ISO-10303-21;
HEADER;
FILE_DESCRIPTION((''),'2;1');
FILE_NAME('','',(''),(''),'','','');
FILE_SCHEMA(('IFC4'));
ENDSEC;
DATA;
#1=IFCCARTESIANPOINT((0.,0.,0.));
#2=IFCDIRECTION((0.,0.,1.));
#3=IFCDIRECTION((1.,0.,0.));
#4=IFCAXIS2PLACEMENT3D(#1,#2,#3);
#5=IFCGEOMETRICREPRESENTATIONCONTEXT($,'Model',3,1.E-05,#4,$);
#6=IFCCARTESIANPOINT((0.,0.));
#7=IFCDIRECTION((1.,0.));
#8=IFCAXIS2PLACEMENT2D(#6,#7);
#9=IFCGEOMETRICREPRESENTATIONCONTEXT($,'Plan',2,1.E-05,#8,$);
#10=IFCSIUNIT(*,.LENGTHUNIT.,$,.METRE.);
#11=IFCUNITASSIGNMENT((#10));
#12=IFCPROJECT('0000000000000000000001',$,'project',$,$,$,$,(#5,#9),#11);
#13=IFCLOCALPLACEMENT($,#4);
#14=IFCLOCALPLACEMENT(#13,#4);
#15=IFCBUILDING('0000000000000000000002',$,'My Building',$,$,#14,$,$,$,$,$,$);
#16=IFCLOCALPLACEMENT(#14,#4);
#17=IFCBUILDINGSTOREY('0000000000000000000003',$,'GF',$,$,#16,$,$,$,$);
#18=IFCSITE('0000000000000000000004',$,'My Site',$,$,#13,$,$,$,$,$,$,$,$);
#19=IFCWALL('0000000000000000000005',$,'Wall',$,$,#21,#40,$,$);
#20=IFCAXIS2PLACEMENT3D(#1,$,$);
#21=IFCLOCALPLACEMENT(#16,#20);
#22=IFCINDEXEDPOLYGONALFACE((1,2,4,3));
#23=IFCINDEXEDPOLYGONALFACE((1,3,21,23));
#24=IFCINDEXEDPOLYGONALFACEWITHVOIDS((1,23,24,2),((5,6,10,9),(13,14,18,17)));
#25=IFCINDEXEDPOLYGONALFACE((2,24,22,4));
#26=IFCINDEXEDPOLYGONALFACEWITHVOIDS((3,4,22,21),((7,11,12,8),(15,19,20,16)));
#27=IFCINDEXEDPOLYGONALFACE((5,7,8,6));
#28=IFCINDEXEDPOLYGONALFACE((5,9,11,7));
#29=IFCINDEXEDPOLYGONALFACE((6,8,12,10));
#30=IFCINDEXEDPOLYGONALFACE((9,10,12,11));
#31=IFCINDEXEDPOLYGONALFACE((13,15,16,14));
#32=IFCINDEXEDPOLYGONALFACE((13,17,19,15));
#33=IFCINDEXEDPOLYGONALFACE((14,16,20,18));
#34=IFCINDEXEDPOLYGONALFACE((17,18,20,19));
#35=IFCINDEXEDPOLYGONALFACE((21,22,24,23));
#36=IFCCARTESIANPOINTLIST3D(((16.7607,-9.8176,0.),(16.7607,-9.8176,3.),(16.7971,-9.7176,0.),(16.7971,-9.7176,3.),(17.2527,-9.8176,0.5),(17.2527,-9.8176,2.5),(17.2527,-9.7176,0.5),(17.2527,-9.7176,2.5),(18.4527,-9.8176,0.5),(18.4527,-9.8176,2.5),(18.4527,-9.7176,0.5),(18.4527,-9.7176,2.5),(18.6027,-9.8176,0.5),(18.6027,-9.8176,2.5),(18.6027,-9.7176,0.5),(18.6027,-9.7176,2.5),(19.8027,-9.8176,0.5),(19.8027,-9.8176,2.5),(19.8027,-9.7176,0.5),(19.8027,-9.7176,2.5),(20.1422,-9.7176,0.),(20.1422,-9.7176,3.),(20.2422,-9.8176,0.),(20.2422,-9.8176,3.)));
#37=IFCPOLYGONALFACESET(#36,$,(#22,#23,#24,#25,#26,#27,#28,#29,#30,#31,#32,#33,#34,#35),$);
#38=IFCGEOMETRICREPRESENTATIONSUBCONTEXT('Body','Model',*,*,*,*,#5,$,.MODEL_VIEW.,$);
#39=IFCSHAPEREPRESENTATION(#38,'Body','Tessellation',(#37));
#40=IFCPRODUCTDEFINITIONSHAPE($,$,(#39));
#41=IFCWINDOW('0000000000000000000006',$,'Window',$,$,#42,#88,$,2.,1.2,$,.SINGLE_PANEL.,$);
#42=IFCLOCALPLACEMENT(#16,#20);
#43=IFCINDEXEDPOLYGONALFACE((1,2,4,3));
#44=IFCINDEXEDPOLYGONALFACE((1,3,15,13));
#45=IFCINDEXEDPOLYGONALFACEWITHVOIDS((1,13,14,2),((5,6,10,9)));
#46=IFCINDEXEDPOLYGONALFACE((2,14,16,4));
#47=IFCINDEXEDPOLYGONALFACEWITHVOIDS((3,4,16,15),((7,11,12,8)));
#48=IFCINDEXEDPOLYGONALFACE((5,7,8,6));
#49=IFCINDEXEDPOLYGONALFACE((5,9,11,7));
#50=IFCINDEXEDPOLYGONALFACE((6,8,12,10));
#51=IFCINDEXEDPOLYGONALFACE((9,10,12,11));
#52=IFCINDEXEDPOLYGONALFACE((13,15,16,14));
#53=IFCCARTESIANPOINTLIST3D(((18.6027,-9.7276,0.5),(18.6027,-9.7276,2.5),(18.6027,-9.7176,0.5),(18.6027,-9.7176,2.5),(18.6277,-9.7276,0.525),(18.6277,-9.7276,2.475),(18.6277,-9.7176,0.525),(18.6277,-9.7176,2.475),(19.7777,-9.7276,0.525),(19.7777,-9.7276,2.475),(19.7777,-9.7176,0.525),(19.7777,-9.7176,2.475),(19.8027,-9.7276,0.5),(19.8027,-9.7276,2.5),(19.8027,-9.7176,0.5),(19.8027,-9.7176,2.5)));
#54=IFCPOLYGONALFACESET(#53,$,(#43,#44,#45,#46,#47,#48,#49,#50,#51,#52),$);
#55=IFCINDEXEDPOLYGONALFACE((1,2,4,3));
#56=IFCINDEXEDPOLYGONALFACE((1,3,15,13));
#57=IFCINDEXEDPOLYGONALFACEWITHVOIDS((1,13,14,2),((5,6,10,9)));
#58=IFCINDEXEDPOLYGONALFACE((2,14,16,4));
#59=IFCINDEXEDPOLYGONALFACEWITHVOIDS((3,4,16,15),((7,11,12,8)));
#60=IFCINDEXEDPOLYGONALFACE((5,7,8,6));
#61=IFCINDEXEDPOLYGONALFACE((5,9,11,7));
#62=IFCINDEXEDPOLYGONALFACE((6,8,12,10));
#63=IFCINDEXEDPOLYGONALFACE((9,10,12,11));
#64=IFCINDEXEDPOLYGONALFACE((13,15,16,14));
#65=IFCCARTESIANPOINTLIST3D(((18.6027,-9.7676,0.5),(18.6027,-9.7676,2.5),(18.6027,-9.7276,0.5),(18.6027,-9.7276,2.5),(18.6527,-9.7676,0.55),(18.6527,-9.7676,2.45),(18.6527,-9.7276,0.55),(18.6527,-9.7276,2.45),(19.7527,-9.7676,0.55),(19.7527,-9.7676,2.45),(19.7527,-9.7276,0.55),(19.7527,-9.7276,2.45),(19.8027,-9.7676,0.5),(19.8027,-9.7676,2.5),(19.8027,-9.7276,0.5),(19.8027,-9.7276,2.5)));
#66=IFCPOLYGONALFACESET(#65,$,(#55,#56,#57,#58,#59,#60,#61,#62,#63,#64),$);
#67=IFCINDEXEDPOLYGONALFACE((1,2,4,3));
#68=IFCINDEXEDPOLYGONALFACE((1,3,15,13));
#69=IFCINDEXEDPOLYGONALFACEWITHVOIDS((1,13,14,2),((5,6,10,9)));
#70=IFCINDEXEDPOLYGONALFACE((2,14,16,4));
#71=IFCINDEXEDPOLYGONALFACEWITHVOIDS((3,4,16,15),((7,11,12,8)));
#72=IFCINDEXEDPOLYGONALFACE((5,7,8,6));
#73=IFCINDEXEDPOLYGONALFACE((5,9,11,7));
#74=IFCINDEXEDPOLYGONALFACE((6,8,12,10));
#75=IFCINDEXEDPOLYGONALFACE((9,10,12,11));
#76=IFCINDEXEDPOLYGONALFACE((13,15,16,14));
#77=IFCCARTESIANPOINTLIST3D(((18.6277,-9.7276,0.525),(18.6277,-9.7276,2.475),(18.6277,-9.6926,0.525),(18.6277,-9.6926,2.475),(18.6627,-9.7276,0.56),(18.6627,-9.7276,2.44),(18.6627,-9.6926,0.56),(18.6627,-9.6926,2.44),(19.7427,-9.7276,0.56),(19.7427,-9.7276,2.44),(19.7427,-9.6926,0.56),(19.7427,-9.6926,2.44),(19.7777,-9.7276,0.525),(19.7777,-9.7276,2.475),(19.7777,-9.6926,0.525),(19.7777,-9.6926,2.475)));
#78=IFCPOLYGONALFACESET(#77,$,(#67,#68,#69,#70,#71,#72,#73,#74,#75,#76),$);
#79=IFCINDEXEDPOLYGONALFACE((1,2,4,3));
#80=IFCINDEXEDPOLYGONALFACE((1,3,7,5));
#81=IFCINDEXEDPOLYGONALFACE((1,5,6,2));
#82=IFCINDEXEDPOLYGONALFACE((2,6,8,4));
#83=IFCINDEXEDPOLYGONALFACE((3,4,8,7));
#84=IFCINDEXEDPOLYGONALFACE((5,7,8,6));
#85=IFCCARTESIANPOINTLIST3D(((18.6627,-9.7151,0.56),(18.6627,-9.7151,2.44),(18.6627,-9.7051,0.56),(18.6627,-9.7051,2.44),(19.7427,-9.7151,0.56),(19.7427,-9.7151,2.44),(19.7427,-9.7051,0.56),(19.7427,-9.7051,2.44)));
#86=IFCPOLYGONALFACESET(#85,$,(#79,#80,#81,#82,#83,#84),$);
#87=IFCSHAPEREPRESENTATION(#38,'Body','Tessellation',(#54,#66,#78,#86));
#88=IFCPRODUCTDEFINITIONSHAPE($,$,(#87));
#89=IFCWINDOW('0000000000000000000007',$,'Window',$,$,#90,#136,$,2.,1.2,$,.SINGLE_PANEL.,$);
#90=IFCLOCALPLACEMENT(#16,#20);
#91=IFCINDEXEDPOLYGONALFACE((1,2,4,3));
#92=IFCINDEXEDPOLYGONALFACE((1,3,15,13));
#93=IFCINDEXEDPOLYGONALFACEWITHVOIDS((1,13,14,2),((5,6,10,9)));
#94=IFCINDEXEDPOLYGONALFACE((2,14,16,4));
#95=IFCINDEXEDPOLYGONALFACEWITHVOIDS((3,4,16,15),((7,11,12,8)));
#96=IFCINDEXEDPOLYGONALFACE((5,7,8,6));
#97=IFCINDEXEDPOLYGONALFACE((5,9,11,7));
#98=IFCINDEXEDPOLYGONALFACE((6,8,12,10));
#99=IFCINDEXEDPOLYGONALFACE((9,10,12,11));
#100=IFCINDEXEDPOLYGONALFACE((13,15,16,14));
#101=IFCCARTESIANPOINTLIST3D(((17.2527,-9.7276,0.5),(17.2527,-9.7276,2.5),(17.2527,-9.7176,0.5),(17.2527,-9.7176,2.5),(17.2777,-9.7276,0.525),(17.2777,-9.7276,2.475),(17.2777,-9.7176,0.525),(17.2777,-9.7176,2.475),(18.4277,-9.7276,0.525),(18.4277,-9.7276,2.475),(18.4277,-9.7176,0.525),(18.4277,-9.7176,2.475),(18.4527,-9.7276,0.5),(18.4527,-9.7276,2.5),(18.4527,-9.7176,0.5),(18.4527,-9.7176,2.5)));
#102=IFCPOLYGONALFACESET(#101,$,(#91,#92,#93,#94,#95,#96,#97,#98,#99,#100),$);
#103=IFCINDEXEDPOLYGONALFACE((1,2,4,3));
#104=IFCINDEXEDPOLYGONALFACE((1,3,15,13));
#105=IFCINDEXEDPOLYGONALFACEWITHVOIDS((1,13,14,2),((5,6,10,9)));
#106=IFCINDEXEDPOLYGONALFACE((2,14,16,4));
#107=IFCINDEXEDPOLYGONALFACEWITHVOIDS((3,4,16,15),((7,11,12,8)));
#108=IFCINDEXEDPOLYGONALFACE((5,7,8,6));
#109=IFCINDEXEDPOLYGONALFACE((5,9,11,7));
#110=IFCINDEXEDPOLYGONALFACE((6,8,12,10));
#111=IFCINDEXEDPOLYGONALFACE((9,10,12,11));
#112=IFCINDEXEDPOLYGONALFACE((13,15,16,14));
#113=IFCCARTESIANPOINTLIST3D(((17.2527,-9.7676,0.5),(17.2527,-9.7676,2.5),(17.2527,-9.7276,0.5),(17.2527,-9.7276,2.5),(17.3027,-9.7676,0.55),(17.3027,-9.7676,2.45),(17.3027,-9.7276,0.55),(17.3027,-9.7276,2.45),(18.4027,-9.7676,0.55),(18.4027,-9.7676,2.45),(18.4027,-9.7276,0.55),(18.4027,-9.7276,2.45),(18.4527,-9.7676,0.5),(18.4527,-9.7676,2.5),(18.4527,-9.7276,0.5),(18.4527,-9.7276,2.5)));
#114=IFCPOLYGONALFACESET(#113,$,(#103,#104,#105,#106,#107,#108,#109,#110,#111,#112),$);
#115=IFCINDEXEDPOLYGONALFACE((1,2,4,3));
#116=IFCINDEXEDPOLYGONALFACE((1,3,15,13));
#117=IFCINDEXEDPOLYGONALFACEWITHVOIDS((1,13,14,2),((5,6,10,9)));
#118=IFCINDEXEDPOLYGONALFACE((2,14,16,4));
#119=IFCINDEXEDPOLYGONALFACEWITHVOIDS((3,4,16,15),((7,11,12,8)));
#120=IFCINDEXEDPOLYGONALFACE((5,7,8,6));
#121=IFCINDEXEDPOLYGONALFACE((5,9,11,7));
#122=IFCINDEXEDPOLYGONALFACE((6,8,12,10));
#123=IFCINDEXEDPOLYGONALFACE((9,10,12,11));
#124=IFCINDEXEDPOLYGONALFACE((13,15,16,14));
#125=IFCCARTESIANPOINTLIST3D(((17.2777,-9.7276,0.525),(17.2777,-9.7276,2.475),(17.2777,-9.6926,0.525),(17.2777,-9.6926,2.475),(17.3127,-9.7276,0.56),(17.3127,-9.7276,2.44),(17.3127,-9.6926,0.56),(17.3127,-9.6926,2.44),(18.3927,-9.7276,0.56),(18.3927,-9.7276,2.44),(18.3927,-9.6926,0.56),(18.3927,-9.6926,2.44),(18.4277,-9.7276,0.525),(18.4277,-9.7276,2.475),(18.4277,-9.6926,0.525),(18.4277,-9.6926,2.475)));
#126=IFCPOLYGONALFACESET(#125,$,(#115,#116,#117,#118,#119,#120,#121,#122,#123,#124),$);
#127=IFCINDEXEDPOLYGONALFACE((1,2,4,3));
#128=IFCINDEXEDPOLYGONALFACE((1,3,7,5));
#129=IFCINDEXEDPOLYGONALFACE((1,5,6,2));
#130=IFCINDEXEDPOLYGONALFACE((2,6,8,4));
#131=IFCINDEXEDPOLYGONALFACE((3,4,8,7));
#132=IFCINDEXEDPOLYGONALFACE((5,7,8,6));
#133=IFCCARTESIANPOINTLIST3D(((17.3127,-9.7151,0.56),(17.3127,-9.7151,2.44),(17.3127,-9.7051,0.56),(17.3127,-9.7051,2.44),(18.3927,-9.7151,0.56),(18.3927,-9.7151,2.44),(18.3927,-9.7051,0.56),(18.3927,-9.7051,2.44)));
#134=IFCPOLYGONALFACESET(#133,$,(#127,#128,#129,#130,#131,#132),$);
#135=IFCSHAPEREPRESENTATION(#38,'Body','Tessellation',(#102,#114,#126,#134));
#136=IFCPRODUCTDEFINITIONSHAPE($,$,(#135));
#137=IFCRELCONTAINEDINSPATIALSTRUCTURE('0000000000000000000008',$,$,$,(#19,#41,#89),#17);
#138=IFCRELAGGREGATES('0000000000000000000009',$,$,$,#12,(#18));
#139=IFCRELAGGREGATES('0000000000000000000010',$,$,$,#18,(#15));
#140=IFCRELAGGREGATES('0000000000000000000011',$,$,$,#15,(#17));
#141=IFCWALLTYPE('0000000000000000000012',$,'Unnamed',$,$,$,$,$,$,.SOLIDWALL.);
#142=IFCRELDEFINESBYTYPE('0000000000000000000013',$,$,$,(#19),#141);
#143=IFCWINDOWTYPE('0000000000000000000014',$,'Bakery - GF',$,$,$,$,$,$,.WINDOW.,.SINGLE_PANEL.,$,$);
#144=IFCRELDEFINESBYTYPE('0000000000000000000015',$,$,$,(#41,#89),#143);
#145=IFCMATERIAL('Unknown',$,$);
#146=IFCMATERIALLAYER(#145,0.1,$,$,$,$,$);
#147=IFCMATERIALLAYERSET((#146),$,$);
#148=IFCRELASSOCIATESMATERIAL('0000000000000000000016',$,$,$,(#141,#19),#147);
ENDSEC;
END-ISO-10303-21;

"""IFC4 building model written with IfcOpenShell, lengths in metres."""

from ifc_helpers import new_model, entity, si_unit, frame, origin_with_axes, origin_2d_with_axis, place, context, subcontext, project, spatial, line, indexed_curve, outline, extrude, shape, source, transform, mapped, material, layer, layer_set, layer_usage, type_object, type_shapes, element, fill, save


model = new_model("IFC4")

# Units and contexts
model_context = context("Model", 3, precision=1e-05, world=origin_with_axes())
plan_context = context("Plan", 2, precision=1e-05, world=origin_2d_with_axis())
body_context_1 = subcontext(model_context, "Body", "Model", "MODEL_VIEW")
body_context_2 = subcontext(plan_context, "Body", "Plan", "PLAN_VIEW")
ifc_project = project(units=[si_unit("LENGTHUNIT", "METRE")], contexts=[model_context, plan_context])

# Site, building, storey
site_placement = place(None, origin_with_axes())
site = spatial("IfcSite", under=ifc_project, at=site_placement, Name="My Site")
building_placement = place(site_placement, origin_with_axes())
building = spatial("IfcBuilding", under=site, at=building_placement, Name="My Building")
storey_placement = place(building_placement, origin_with_axes())
storey = spatial("IfcBuildingStorey", under=building, at=storey_placement, Name="GF")

# Shared definitions
ifc_material = material(Name="Unknown")

# Shared definitions
ifc_layer_1 = layer(ifc_material, 0.1)
ifc_layer_set_1 = layer_set([ifc_layer_1])
wall_type = type_object("IfcWallType", Name="Unnamed", PredefinedType="SOLIDWALL", material=ifc_layer_set_1)

# Wall, openings, windows
shared_shape_1 = source(origin_with_axes(), body_context_1, "Body", "SweptSolid", [
    extrude(outline(indexed_curve([(0.0, 0.0), (1.2, 0.0), (1.2, 2.0), (0.0, 2.0)], segments=[line(1, 2, 3, 4, 1)])), frame((0.0, -0.6, 0.0), z_axis=(0.0, -1.0, 0.0), x_axis=(1.0, 0.0, 0.0)), (0.0, 0.0, -1.0), 1.2),
])
window_type = type_object("IfcWindowType", Name="Bakery - GF", PartitioningType="SINGLE_PANEL", PredefinedType="WINDOW")
shared_shape_2 = source(origin_with_axes(), body_context_1, "Body", "SweptSolid", [
    extrude(outline(indexed_curve([(0.0, 0.0), (1.2, 0.0), (1.2, 2.0), (0.0, 2.0)], segments=[line(1, 2, 3, 4, 1)]), holes=[indexed_curve([(0.025, 0.025), (1.175, 0.025), (1.175, 1.975), (0.025, 1.975)], segments=[line(1, 2, 3, 4, 1)])]), frame((0.0, 0.09, 0.0), z_axis=(0.0, -1.0, 0.0), x_axis=(1.0, 0.0, 0.0)), (0.0, 0.0, -1.0), 0.01),
    extrude(outline(indexed_curve([(0.0, 0.0), (1.2, 0.0), (1.2, 2.0), (0.0, 2.0)], segments=[line(1, 2, 3, 4, 1)]), holes=[indexed_curve([(0.05, 0.05), (1.15, 0.05), (1.15, 1.95), (0.05, 1.95)], segments=[line(1, 2, 3, 4, 1)])]), frame((0.0, 0.05, 0.0), z_axis=(0.0, -1.0, 0.0), x_axis=(1.0, 0.0, 0.0)), (0.0, 0.0, -1.0), 0.04),
    extrude(outline(indexed_curve([(0.0, 0.0), (1.15, 0.0), (1.15, 1.95), (0.0, 1.95)], segments=[line(1, 2, 3, 4, 1)]), holes=[indexed_curve([(0.035, 0.035), (1.115, 0.035), (1.115, 1.915), (0.035, 1.915)], segments=[line(1, 2, 3, 4, 1)])]), frame((0.025, 0.09, 0.025), z_axis=(0.0, -1.0, 0.0), x_axis=(1.0, 0.0, 0.0)), (0.0, 0.0, -1.0), 0.035),
    extrude(outline(indexed_curve([(0.035, 0.035), (1.115, 0.035), (1.115, 1.915), (0.035, 1.915)], segments=[line(1, 2, 3, 4, 1)])), frame((0.025, 0.1025, 0.025), z_axis=(0.0, -1.0, 0.0), x_axis=(1.0, 0.0, 0.0)), (0.0, 0.0, -1.0), 0.01),
])
shared_shape_3 = source(origin_with_axes(), body_context_2, "Body", "Curve2D", [
    entity("IfcIndexedPolyCurve", entity("IfcCartesianPointList2D", [[0.05, 0.05], [1.15, 0.05]])),
    entity("IfcIndexedPolyCurve", entity("IfcCartesianPointList2D", [[0.0, 0.1], [0.025, 0.1], [0.025, 0.09], [0.05, 0.09], [0.05, 0.05], [0.0, 0.05]]), [entity("IfcLineIndex", [1, 2, 3, 4, 5, 6, 1])]),
    entity("IfcIndexedPolyCurve", entity("IfcCartesianPointList2D", [[1.2, 0.1], [1.175, 0.1], [1.175, 0.09], [1.15, 0.09], [1.15, 0.05], [1.2, 0.05]]), [entity("IfcLineIndex", [1, 2, 3, 4, 5, 6, 1])]),
    entity("IfcIndexedPolyCurve", entity("IfcCartesianPointList2D", [[0.025, 0.09], [0.06, 0.09], [0.06, 0.125], [0.025, 0.125]]), [entity("IfcLineIndex", [1, 2, 3, 4, 1])]),
    entity("IfcIndexedPolyCurve", entity("IfcCartesianPointList2D", [[1.175, 0.09], [1.14, 0.09], [1.14, 0.125], [1.175, 0.125]]), [entity("IfcLineIndex", [1, 2, 3, 4, 1])]),
    entity("IfcIndexedPolyCurve", entity("IfcCartesianPointList2D", [[0.06, 0.09], [1.14, 0.09]])),
    entity("IfcIndexedPolyCurve", entity("IfcCartesianPointList2D", [[0.06, 0.125], [1.14, 0.125]])),
    entity("IfcIndexedPolyCurve", entity("IfcCartesianPointList2D", [[0.06, 0.1075], [1.14, 0.1075]])),
])
type_shapes(window_type, [shared_shape_2, shared_shape_3])
ifc_layer_usage_1 = layer_usage(ifc_layer_set_1, "AXIS2", "POSITIVE", 0.0)
wall_1_placement = place(storey_placement, frame((16.7607, -9.8176, 0.0), z_axis=(0.0, 0.0, 1.0), x_axis=(1.0, 0.0, 0.0)))
wall_1 = element("IfcWall", 1, at=wall_1_placement, inside=storey, type_object=wall_type, material=ifc_layer_usage_1, Name="Wall", context=body_context_1, shape_type="SweptSolid", body=[
    extrude(outline(indexed_curve([(0.0, 0.0), (0.0364, 0.1), (3.3816, 0.1), (3.4816, 0.0)], segments=[line(1, 2, 3, 4, 1)])), origin_with_axes(), (0.0, 0.0, 1.0), 3.0),
])
opening_1_placement = place(wall_1_placement, frame((1.842, 0.0, 0.5), z_axis=(0.0, 0.0, 1.0), x_axis=(1.0, 0.0, 0.0)))
opening_1 = element("IfcOpeningElement", 2, at=opening_1_placement, cuts=wall_1, PredefinedType="OPENING", context=body_context_1, shape_type="MappedRepresentation", body=[
    mapped(shared_shape_1, transform((0.0, 0.0, 0.0), x_axis=(1.0, 0.0, 0.0), y_axis=(0.0, 1.0, 0.0), z_axis=(0.0, 0.0, 1.0), scale=1.0)),
])
opening_2_placement = place(wall_1_placement, frame((0.492, 0.0, 0.5), z_axis=(0.0, 0.0, 1.0), x_axis=(1.0, 0.0, 0.0)))
opening_2 = element("IfcOpeningElement", 3, at=opening_2_placement, cuts=wall_1, PredefinedType="OPENING", context=body_context_1, shape_type="MappedRepresentation", body=[
    mapped(shared_shape_1, transform((0.0, 0.0, 0.0), x_axis=(1.0, 0.0, 0.0), y_axis=(0.0, 1.0, 0.0), z_axis=(0.0, 0.0, 1.0), scale=1.0)),
])
window_1_placement = place(opening_1_placement, origin_with_axes())
window_1 = element("IfcWindow", 4, at=window_1_placement, inside=storey, type_object=window_type, Name="Window", OverallHeight=2.0, OverallWidth=1.2, PartitioningType="SINGLE_PANEL", shapes=[
    shape(body_context_1, "Body", "MappedRepresentation", [mapped(shared_shape_2, transform((0.0, 0.0, 0.0), x_axis=(1.0, 0.0, 0.0), y_axis=(0.0, 1.0, 0.0), z_axis=(0.0, 0.0, 1.0), scale=1.0))]),
    shape(body_context_2, "Body", "MappedRepresentation", [mapped(shared_shape_3, transform((0.0, 0.0, 0.0), x_axis=(1.0, 0.0, 0.0), y_axis=(0.0, 1.0, 0.0), z_axis=(0.0, 0.0, 1.0), scale=1.0))]),
])
fill(opening_1, window_1)
window_2_placement = place(opening_2_placement, origin_with_axes())
window_2 = element("IfcWindow", 5, at=window_2_placement, inside=storey, type_object=window_type, Name="Window", OverallHeight=2.0, OverallWidth=1.2, PartitioningType="SINGLE_PANEL", shapes=[
    shape(body_context_1, "Body", "MappedRepresentation", [mapped(shared_shape_2, transform((0.0, 0.0, 0.0), x_axis=(1.0, 0.0, 0.0), y_axis=(0.0, 1.0, 0.0), z_axis=(0.0, 0.0, 1.0), scale=1.0))]),
    shape(body_context_2, "Body", "MappedRepresentation", [mapped(shared_shape_3, transform((0.0, 0.0, 0.0), x_axis=(1.0, 0.0, 0.0), y_axis=(0.0, 1.0, 0.0), z_axis=(0.0, 0.0, 1.0), scale=1.0))]),
])
fill(opening_2, window_2)

save(model, "model.ifc")
